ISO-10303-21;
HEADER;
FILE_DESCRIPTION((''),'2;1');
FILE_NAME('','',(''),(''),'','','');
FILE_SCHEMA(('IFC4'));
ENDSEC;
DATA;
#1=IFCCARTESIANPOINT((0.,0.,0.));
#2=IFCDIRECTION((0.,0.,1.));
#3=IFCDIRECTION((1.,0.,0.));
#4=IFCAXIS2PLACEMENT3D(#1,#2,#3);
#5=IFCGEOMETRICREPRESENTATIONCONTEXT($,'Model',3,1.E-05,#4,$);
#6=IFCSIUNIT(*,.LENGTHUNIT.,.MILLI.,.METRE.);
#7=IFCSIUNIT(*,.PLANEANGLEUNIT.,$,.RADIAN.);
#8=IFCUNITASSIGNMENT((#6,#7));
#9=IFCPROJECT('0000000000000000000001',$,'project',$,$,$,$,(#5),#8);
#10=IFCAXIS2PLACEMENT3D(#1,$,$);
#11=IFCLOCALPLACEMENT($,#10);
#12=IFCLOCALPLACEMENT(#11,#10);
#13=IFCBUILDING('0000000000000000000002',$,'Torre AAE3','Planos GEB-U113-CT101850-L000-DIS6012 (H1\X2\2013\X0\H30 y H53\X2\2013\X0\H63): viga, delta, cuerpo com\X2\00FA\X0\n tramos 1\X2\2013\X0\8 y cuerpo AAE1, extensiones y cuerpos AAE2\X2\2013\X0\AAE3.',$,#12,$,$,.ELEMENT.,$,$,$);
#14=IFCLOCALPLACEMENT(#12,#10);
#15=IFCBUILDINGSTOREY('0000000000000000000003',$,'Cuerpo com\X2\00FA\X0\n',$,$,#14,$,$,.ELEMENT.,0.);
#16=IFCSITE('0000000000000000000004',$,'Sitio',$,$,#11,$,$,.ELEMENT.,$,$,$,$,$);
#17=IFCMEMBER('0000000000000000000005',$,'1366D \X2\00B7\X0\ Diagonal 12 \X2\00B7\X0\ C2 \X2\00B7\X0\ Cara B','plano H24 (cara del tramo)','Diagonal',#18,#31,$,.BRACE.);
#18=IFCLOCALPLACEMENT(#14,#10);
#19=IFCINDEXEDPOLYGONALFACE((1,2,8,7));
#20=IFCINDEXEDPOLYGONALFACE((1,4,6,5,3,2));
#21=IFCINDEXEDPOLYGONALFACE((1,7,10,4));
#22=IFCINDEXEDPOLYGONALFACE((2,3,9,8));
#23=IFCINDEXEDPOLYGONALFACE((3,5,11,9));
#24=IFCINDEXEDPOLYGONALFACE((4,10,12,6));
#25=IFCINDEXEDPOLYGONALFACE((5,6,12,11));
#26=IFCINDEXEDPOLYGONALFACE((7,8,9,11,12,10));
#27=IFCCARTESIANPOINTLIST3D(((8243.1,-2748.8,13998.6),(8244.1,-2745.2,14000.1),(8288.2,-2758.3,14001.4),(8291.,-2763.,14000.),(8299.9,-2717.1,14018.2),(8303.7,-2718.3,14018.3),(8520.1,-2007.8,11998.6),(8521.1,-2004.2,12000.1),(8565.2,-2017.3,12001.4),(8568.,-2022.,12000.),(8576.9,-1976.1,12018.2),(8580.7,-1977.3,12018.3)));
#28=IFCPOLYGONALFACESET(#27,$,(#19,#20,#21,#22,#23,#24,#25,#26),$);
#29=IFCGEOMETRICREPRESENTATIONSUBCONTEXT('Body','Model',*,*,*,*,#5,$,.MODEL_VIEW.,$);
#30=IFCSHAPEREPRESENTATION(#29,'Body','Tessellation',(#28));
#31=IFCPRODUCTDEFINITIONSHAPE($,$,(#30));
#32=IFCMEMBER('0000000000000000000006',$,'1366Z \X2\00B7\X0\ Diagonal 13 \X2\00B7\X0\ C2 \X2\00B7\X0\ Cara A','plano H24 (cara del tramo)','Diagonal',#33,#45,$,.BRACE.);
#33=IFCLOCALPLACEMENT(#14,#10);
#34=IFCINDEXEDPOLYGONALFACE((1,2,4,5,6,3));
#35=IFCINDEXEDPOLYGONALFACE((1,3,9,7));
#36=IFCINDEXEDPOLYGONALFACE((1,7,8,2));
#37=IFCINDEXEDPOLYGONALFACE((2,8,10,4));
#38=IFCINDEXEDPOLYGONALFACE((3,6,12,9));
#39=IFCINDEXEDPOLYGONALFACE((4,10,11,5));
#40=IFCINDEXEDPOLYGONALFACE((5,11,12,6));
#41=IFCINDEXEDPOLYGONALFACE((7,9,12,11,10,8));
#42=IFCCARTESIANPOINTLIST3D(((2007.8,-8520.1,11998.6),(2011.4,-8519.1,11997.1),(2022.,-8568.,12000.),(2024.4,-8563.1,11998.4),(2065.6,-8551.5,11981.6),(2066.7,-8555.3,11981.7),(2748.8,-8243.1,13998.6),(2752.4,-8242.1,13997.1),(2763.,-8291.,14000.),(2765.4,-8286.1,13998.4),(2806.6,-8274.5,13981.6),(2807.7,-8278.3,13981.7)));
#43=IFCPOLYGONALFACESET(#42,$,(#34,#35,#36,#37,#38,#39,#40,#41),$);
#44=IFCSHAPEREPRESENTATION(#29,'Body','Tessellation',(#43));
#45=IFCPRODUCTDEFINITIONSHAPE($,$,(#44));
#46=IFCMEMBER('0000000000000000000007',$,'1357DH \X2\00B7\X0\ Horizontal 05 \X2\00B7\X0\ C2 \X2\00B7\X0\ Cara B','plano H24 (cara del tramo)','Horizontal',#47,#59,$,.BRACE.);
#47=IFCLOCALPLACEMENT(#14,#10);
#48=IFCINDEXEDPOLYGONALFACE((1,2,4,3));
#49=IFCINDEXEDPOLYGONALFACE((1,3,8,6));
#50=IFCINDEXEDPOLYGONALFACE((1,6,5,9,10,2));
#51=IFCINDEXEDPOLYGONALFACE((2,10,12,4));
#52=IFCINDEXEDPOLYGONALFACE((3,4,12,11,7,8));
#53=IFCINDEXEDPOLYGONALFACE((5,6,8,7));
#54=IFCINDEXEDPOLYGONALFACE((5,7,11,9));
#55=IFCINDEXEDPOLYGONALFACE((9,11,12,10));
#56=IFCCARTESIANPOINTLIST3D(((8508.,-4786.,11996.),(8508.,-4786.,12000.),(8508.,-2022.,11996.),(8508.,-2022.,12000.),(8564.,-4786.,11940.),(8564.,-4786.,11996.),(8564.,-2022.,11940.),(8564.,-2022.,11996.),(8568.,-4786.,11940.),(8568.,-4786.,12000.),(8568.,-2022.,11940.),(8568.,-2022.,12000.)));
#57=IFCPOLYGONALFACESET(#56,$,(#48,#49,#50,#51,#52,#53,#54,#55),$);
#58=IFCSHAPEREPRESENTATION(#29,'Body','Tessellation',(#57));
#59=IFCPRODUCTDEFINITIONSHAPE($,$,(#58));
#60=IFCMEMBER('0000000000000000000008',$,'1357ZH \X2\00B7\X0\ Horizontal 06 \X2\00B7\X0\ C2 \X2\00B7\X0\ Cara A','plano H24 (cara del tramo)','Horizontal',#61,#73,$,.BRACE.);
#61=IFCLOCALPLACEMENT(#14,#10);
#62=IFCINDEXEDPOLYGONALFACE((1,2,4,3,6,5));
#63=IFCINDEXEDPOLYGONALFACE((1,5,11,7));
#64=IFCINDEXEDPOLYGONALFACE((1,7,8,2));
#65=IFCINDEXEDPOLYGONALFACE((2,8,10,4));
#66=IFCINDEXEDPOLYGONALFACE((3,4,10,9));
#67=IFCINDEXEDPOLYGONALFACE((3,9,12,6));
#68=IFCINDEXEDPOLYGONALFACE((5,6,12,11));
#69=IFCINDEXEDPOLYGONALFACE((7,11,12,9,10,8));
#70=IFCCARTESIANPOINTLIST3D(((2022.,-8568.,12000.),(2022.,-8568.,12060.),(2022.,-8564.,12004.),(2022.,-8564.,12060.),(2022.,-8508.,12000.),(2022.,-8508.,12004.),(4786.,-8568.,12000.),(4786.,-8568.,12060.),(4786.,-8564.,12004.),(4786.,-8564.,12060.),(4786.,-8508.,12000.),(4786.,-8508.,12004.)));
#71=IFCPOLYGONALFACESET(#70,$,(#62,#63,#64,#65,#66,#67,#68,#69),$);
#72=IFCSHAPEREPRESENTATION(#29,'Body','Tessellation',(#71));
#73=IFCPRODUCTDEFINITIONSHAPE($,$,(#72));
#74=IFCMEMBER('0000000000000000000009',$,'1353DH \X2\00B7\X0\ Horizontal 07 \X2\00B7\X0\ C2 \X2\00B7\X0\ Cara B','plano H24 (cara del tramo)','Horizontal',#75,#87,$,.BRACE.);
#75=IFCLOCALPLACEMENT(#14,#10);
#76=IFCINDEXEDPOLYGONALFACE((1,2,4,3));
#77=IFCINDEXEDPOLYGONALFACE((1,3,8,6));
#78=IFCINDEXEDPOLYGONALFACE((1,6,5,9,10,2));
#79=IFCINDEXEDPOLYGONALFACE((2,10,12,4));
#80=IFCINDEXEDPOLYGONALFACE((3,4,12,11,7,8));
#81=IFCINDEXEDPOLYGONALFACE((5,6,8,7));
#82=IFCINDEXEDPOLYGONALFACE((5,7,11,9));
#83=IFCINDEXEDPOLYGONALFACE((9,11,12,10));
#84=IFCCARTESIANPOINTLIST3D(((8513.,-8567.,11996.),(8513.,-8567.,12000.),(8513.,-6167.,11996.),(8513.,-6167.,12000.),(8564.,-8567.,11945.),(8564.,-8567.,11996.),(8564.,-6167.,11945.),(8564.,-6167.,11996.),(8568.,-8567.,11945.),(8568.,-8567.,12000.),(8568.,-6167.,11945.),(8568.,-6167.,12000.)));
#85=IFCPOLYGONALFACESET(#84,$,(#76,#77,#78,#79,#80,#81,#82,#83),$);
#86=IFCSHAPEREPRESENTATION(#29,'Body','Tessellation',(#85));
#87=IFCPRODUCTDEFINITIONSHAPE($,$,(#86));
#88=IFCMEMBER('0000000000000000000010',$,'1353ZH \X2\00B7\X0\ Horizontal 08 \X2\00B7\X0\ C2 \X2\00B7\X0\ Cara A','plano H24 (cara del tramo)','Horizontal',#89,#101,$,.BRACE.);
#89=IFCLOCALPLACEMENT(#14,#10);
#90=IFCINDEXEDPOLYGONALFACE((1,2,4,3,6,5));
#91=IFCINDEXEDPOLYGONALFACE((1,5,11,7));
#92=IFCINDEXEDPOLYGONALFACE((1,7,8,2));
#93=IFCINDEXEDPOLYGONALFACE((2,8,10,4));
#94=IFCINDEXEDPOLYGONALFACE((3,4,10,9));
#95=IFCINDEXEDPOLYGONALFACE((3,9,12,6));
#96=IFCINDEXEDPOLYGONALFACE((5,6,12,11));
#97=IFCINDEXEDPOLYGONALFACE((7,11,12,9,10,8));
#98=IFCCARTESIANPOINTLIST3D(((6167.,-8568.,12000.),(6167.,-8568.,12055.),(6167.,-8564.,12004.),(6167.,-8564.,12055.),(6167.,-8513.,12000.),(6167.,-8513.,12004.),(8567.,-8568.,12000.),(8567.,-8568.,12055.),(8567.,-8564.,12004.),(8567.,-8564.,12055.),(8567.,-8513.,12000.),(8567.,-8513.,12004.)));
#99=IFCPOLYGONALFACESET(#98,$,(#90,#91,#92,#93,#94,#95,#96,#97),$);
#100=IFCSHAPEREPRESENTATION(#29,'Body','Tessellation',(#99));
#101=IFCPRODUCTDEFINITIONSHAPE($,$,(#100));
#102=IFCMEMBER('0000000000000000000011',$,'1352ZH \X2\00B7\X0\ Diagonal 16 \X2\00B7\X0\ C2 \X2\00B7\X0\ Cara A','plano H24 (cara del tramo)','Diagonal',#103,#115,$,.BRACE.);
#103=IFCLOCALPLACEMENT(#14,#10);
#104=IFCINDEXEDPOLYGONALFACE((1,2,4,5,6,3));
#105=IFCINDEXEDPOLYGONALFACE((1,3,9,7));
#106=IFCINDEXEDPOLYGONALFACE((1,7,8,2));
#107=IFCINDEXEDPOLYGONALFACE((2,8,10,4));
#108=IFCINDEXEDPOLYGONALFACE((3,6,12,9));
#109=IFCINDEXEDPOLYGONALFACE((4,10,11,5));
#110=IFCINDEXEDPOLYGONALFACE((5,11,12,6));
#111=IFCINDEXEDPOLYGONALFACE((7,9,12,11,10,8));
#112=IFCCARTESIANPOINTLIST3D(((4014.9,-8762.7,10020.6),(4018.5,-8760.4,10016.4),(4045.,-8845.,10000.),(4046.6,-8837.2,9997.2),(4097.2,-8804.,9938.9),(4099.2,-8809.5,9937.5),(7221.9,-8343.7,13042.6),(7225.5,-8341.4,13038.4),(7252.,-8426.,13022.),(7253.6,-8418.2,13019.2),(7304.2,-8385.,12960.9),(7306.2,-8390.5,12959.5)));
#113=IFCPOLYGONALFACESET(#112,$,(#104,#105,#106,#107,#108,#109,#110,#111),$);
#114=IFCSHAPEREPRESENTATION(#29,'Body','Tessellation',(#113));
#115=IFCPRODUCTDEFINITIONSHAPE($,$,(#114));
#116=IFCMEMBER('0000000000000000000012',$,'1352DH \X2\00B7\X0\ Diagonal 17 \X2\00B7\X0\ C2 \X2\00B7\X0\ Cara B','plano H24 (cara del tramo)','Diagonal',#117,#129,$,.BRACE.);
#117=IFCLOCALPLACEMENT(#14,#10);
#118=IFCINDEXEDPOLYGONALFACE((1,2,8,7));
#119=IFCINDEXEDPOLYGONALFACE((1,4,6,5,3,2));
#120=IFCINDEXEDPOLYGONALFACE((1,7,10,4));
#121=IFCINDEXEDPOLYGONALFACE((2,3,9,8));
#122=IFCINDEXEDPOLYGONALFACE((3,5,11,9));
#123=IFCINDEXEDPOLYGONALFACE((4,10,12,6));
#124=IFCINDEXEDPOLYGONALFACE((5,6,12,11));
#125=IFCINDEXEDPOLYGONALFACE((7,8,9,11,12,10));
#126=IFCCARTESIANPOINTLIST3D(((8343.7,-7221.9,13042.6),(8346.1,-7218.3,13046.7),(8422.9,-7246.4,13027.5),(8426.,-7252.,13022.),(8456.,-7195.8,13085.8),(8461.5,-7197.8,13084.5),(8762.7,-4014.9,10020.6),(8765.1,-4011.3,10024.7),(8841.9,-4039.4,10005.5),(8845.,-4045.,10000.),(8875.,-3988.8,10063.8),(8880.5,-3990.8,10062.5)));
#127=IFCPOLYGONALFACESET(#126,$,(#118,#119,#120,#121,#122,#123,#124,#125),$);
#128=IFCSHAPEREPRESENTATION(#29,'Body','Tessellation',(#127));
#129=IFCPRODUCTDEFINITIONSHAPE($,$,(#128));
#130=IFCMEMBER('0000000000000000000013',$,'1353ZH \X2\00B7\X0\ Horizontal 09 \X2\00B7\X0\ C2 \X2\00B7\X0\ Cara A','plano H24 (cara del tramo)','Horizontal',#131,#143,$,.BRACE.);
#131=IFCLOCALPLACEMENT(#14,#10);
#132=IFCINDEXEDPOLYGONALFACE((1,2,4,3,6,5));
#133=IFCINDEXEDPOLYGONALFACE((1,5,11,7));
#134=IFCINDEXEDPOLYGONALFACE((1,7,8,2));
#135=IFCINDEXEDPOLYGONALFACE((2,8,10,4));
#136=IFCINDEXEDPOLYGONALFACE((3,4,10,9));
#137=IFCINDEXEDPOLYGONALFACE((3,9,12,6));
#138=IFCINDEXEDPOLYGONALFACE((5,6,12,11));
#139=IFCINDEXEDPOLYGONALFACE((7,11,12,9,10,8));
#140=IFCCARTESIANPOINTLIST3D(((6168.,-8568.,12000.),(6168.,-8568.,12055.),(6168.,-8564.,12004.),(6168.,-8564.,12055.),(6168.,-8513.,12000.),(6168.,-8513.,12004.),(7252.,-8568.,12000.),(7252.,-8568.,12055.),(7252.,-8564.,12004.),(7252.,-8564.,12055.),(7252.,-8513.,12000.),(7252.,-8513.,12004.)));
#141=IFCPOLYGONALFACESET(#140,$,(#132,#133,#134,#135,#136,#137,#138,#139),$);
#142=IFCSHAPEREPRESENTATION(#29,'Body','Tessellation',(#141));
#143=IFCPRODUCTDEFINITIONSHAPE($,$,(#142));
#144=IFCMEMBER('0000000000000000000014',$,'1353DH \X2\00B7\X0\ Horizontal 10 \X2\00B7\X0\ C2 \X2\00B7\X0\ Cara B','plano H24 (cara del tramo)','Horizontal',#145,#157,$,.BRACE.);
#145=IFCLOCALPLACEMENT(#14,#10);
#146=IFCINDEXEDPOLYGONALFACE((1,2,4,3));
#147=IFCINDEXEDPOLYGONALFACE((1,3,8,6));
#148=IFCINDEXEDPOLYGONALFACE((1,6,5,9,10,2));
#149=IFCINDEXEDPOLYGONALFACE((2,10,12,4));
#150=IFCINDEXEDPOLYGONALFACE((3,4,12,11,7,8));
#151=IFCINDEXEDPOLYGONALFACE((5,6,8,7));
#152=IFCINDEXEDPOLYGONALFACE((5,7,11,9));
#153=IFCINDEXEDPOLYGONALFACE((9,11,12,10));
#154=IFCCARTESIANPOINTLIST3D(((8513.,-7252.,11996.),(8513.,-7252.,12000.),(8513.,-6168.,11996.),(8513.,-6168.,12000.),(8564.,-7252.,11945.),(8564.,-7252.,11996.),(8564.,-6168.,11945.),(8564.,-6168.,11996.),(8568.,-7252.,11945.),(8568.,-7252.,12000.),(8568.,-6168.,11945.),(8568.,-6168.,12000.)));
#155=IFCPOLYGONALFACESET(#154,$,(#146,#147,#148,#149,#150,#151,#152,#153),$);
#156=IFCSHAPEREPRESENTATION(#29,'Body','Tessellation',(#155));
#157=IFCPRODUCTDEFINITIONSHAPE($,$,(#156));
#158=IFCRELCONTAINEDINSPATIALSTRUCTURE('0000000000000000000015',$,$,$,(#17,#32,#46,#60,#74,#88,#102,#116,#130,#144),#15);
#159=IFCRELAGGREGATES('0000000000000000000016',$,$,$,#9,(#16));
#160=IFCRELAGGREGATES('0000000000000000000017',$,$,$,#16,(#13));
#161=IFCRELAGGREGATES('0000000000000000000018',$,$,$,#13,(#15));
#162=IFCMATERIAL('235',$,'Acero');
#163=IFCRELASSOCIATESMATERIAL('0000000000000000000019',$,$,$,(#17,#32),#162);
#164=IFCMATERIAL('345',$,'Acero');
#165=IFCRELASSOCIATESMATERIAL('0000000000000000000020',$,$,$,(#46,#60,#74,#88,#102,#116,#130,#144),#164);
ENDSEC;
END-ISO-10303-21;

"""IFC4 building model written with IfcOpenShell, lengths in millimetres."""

from ifc_helpers import new_model, si_unit, frame, frame_2d, origin, origin_with_axes, place, context, subcontext, project, spatial, l_section, extrude, material, element, save


model = new_model("IFC4")

# Units and contexts
model_context = context("Model", 3, precision=1e-05, world=origin_with_axes())
body_context = subcontext(model_context, "Body", "Model", "MODEL_VIEW")
ifc_project = project(units=[si_unit("LENGTHUNIT", "METRE", prefix="MILLI"), si_unit("PLANEANGLEUNIT", "RADIAN")], contexts=[model_context])

# Site, building, storey
site_placement = place(None, origin())
site = spatial("IfcSite", under=ifc_project, at=site_placement, Name="Sitio", CompositionType="ELEMENT")
building_placement = place(site_placement, origin())
building = spatial("IfcBuilding", under=site, at=building_placement, Name="Torre AAE3", Description="Planos GEB-U113-CT101850-L000-DIS6012 (H1–H30 y H53–H63): viga, delta, cuerpo común tramos 1–8 y cuerpo AAE1, extensiones y cuerpos AAE2–AAE3.", CompositionType="ELEMENT")
storey_placement = place(building_placement, origin())
storey = spatial("IfcBuildingStorey", under=building, at=storey_placement, Name="Cuerpo común", CompositionType="ELEMENT", Elevation=0.0)

# Members
ifc_material_1 = material(Name="345", Category="Acero")
ifc_material_2 = material(Name="235", Category="Acero")
for number, where, z_axis, x_axis, name in (
    (1, (8291.0, -2763.0, 14000.0), (0.128791, 0.344528, -0.9299), (-0.958588, 0.283443, -0.027749), "1366D · Diagonal 12 · C2 · Cara B"),
    (2, (2763.0, -8291.0, 14000.0), (-0.344528, -0.128791, -0.9299), (-0.283443, 0.958588, -0.027749), "1366Z · Diagonal 13 · C2 · Cara A"),
):
    element("IfcMember", number, at=place(storey_placement, frame(where, z_axis=z_axis, x_axis=x_axis)), inside=storey, material=ifc_material_2, Name=name, Description="plano H24 (cara del tramo)", ObjectType="Diagonal", PredefinedType="BRACE", context=body_context, shape_type="SweptSolid", body=[
        extrude(l_section(Depth=50.0, Width=50.0, Thickness=4.0, at=frame_2d((25.0, 25.0))), None, (0.0, 0.0, 1.0), 2150.8),
    ])
for number, where, z_axis, x_axis, name in (
    (3, (8568.0, -2022.0, 12000.0), (0.0, -1.0, 0.0), (-1.0, 0.0, 0.0), "1357DH · Horizontal 05 · C2 · Cara B"),
    (4, (2022.0, -8568.0, 12000.0), (1.0, 0.0, 0.0), (0.0, 1.0, 0.0), "1357ZH · Horizontal 06 · C2 · Cara A"),
):
    element("IfcMember", number, at=place(storey_placement, frame(where, z_axis=z_axis, x_axis=x_axis)), inside=storey, material=ifc_material_1, Name=name, Description="plano H24 (cara del tramo)", ObjectType="Horizontal", PredefinedType="BRACE", context=body_context, shape_type="SweptSolid", body=[
        extrude(l_section(Depth=60.0, Width=60.0, Thickness=4.0, at=frame_2d((30.0, 30.0))), None, (0.0, 0.0, 1.0), 2764.0),
    ])
for number, where, z_axis, x_axis, name in (
    (5, (8568.0, -6167.0, 12000.0), (0.0, -1.0, 0.0), (-1.0, 0.0, 0.0), "1353DH · Horizontal 07 · C2 · Cara B"),
    (6, (6167.0, -8568.0, 12000.0), (1.0, 0.0, 0.0), (0.0, 1.0, 0.0), "1353ZH · Horizontal 08 · C2 · Cara A"),
):
    element("IfcMember", number, at=place(storey_placement, frame(where, z_axis=z_axis, x_axis=x_axis)), inside=storey, material=ifc_material_1, Name=name, Description="plano H24 (cara del tramo)", ObjectType="Horizontal", PredefinedType="BRACE", context=body_context, shape_type="SweptSolid", body=[
        extrude(l_section(Depth=55.0, Width=55.0, Thickness=4.0, at=frame_2d((27.5, 27.5))), None, (0.0, 0.0, 1.0), 2400.0),
    ])
for number, where, z_axis, x_axis, name in (
    (7, (7252.0, -8426.0, 13022.0), (-0.724519, -0.09466, -0.682724), (-0.334757, 0.91418, 0.228499), "1352ZH · Diagonal 16 · C2 · Cara A"),
    (8, (8426.0, -7252.0, 13022.0), (0.09466, 0.724519, -0.682724), (-0.91418, 0.334757, 0.228499), "1352DH · Diagonal 17 · C2 · Cara B"),
):
    element("IfcMember", number, at=place(storey_placement, frame(where, z_axis=z_axis, x_axis=x_axis)), inside=storey, material=ifc_material_1, Name=name, Description="plano H24 (cara del tramo)", ObjectType="Diagonal", PredefinedType="BRACE", context=body_context, shape_type="SweptSolid", body=[
        extrude(l_section(Depth=90.0, Width=90.0, Thickness=6.0, at=frame_2d((45.0, 45.0))), None, (0.0, 0.0, 1.0), 4426.4),
    ])
for number, where, z_axis, x_axis, name in (
    (9, (6168.0, -8568.0, 12000.0), (1.0, 0.0, 0.0), (0.0, 1.0, 0.0), "1353ZH · Horizontal 09 · C2 · Cara A"),
    (10, (8568.0, -6168.0, 12000.0), (0.0, -1.0, 0.0), (-1.0, 0.0, 0.0), "1353DH · Horizontal 10 · C2 · Cara B"),
):
    element("IfcMember", number, at=place(storey_placement, frame(where, z_axis=z_axis, x_axis=x_axis)), inside=storey, material=ifc_material_1, Name=name, Description="plano H24 (cara del tramo)", ObjectType="Horizontal", PredefinedType="BRACE", context=body_context, shape_type="SweptSolid", body=[
        extrude(l_section(Depth=55.0, Width=55.0, Thickness=4.0, at=frame_2d((27.5, 27.5))), None, (0.0, 0.0, 1.0), 1084.0),
    ])

save(model, "model.ifc")
